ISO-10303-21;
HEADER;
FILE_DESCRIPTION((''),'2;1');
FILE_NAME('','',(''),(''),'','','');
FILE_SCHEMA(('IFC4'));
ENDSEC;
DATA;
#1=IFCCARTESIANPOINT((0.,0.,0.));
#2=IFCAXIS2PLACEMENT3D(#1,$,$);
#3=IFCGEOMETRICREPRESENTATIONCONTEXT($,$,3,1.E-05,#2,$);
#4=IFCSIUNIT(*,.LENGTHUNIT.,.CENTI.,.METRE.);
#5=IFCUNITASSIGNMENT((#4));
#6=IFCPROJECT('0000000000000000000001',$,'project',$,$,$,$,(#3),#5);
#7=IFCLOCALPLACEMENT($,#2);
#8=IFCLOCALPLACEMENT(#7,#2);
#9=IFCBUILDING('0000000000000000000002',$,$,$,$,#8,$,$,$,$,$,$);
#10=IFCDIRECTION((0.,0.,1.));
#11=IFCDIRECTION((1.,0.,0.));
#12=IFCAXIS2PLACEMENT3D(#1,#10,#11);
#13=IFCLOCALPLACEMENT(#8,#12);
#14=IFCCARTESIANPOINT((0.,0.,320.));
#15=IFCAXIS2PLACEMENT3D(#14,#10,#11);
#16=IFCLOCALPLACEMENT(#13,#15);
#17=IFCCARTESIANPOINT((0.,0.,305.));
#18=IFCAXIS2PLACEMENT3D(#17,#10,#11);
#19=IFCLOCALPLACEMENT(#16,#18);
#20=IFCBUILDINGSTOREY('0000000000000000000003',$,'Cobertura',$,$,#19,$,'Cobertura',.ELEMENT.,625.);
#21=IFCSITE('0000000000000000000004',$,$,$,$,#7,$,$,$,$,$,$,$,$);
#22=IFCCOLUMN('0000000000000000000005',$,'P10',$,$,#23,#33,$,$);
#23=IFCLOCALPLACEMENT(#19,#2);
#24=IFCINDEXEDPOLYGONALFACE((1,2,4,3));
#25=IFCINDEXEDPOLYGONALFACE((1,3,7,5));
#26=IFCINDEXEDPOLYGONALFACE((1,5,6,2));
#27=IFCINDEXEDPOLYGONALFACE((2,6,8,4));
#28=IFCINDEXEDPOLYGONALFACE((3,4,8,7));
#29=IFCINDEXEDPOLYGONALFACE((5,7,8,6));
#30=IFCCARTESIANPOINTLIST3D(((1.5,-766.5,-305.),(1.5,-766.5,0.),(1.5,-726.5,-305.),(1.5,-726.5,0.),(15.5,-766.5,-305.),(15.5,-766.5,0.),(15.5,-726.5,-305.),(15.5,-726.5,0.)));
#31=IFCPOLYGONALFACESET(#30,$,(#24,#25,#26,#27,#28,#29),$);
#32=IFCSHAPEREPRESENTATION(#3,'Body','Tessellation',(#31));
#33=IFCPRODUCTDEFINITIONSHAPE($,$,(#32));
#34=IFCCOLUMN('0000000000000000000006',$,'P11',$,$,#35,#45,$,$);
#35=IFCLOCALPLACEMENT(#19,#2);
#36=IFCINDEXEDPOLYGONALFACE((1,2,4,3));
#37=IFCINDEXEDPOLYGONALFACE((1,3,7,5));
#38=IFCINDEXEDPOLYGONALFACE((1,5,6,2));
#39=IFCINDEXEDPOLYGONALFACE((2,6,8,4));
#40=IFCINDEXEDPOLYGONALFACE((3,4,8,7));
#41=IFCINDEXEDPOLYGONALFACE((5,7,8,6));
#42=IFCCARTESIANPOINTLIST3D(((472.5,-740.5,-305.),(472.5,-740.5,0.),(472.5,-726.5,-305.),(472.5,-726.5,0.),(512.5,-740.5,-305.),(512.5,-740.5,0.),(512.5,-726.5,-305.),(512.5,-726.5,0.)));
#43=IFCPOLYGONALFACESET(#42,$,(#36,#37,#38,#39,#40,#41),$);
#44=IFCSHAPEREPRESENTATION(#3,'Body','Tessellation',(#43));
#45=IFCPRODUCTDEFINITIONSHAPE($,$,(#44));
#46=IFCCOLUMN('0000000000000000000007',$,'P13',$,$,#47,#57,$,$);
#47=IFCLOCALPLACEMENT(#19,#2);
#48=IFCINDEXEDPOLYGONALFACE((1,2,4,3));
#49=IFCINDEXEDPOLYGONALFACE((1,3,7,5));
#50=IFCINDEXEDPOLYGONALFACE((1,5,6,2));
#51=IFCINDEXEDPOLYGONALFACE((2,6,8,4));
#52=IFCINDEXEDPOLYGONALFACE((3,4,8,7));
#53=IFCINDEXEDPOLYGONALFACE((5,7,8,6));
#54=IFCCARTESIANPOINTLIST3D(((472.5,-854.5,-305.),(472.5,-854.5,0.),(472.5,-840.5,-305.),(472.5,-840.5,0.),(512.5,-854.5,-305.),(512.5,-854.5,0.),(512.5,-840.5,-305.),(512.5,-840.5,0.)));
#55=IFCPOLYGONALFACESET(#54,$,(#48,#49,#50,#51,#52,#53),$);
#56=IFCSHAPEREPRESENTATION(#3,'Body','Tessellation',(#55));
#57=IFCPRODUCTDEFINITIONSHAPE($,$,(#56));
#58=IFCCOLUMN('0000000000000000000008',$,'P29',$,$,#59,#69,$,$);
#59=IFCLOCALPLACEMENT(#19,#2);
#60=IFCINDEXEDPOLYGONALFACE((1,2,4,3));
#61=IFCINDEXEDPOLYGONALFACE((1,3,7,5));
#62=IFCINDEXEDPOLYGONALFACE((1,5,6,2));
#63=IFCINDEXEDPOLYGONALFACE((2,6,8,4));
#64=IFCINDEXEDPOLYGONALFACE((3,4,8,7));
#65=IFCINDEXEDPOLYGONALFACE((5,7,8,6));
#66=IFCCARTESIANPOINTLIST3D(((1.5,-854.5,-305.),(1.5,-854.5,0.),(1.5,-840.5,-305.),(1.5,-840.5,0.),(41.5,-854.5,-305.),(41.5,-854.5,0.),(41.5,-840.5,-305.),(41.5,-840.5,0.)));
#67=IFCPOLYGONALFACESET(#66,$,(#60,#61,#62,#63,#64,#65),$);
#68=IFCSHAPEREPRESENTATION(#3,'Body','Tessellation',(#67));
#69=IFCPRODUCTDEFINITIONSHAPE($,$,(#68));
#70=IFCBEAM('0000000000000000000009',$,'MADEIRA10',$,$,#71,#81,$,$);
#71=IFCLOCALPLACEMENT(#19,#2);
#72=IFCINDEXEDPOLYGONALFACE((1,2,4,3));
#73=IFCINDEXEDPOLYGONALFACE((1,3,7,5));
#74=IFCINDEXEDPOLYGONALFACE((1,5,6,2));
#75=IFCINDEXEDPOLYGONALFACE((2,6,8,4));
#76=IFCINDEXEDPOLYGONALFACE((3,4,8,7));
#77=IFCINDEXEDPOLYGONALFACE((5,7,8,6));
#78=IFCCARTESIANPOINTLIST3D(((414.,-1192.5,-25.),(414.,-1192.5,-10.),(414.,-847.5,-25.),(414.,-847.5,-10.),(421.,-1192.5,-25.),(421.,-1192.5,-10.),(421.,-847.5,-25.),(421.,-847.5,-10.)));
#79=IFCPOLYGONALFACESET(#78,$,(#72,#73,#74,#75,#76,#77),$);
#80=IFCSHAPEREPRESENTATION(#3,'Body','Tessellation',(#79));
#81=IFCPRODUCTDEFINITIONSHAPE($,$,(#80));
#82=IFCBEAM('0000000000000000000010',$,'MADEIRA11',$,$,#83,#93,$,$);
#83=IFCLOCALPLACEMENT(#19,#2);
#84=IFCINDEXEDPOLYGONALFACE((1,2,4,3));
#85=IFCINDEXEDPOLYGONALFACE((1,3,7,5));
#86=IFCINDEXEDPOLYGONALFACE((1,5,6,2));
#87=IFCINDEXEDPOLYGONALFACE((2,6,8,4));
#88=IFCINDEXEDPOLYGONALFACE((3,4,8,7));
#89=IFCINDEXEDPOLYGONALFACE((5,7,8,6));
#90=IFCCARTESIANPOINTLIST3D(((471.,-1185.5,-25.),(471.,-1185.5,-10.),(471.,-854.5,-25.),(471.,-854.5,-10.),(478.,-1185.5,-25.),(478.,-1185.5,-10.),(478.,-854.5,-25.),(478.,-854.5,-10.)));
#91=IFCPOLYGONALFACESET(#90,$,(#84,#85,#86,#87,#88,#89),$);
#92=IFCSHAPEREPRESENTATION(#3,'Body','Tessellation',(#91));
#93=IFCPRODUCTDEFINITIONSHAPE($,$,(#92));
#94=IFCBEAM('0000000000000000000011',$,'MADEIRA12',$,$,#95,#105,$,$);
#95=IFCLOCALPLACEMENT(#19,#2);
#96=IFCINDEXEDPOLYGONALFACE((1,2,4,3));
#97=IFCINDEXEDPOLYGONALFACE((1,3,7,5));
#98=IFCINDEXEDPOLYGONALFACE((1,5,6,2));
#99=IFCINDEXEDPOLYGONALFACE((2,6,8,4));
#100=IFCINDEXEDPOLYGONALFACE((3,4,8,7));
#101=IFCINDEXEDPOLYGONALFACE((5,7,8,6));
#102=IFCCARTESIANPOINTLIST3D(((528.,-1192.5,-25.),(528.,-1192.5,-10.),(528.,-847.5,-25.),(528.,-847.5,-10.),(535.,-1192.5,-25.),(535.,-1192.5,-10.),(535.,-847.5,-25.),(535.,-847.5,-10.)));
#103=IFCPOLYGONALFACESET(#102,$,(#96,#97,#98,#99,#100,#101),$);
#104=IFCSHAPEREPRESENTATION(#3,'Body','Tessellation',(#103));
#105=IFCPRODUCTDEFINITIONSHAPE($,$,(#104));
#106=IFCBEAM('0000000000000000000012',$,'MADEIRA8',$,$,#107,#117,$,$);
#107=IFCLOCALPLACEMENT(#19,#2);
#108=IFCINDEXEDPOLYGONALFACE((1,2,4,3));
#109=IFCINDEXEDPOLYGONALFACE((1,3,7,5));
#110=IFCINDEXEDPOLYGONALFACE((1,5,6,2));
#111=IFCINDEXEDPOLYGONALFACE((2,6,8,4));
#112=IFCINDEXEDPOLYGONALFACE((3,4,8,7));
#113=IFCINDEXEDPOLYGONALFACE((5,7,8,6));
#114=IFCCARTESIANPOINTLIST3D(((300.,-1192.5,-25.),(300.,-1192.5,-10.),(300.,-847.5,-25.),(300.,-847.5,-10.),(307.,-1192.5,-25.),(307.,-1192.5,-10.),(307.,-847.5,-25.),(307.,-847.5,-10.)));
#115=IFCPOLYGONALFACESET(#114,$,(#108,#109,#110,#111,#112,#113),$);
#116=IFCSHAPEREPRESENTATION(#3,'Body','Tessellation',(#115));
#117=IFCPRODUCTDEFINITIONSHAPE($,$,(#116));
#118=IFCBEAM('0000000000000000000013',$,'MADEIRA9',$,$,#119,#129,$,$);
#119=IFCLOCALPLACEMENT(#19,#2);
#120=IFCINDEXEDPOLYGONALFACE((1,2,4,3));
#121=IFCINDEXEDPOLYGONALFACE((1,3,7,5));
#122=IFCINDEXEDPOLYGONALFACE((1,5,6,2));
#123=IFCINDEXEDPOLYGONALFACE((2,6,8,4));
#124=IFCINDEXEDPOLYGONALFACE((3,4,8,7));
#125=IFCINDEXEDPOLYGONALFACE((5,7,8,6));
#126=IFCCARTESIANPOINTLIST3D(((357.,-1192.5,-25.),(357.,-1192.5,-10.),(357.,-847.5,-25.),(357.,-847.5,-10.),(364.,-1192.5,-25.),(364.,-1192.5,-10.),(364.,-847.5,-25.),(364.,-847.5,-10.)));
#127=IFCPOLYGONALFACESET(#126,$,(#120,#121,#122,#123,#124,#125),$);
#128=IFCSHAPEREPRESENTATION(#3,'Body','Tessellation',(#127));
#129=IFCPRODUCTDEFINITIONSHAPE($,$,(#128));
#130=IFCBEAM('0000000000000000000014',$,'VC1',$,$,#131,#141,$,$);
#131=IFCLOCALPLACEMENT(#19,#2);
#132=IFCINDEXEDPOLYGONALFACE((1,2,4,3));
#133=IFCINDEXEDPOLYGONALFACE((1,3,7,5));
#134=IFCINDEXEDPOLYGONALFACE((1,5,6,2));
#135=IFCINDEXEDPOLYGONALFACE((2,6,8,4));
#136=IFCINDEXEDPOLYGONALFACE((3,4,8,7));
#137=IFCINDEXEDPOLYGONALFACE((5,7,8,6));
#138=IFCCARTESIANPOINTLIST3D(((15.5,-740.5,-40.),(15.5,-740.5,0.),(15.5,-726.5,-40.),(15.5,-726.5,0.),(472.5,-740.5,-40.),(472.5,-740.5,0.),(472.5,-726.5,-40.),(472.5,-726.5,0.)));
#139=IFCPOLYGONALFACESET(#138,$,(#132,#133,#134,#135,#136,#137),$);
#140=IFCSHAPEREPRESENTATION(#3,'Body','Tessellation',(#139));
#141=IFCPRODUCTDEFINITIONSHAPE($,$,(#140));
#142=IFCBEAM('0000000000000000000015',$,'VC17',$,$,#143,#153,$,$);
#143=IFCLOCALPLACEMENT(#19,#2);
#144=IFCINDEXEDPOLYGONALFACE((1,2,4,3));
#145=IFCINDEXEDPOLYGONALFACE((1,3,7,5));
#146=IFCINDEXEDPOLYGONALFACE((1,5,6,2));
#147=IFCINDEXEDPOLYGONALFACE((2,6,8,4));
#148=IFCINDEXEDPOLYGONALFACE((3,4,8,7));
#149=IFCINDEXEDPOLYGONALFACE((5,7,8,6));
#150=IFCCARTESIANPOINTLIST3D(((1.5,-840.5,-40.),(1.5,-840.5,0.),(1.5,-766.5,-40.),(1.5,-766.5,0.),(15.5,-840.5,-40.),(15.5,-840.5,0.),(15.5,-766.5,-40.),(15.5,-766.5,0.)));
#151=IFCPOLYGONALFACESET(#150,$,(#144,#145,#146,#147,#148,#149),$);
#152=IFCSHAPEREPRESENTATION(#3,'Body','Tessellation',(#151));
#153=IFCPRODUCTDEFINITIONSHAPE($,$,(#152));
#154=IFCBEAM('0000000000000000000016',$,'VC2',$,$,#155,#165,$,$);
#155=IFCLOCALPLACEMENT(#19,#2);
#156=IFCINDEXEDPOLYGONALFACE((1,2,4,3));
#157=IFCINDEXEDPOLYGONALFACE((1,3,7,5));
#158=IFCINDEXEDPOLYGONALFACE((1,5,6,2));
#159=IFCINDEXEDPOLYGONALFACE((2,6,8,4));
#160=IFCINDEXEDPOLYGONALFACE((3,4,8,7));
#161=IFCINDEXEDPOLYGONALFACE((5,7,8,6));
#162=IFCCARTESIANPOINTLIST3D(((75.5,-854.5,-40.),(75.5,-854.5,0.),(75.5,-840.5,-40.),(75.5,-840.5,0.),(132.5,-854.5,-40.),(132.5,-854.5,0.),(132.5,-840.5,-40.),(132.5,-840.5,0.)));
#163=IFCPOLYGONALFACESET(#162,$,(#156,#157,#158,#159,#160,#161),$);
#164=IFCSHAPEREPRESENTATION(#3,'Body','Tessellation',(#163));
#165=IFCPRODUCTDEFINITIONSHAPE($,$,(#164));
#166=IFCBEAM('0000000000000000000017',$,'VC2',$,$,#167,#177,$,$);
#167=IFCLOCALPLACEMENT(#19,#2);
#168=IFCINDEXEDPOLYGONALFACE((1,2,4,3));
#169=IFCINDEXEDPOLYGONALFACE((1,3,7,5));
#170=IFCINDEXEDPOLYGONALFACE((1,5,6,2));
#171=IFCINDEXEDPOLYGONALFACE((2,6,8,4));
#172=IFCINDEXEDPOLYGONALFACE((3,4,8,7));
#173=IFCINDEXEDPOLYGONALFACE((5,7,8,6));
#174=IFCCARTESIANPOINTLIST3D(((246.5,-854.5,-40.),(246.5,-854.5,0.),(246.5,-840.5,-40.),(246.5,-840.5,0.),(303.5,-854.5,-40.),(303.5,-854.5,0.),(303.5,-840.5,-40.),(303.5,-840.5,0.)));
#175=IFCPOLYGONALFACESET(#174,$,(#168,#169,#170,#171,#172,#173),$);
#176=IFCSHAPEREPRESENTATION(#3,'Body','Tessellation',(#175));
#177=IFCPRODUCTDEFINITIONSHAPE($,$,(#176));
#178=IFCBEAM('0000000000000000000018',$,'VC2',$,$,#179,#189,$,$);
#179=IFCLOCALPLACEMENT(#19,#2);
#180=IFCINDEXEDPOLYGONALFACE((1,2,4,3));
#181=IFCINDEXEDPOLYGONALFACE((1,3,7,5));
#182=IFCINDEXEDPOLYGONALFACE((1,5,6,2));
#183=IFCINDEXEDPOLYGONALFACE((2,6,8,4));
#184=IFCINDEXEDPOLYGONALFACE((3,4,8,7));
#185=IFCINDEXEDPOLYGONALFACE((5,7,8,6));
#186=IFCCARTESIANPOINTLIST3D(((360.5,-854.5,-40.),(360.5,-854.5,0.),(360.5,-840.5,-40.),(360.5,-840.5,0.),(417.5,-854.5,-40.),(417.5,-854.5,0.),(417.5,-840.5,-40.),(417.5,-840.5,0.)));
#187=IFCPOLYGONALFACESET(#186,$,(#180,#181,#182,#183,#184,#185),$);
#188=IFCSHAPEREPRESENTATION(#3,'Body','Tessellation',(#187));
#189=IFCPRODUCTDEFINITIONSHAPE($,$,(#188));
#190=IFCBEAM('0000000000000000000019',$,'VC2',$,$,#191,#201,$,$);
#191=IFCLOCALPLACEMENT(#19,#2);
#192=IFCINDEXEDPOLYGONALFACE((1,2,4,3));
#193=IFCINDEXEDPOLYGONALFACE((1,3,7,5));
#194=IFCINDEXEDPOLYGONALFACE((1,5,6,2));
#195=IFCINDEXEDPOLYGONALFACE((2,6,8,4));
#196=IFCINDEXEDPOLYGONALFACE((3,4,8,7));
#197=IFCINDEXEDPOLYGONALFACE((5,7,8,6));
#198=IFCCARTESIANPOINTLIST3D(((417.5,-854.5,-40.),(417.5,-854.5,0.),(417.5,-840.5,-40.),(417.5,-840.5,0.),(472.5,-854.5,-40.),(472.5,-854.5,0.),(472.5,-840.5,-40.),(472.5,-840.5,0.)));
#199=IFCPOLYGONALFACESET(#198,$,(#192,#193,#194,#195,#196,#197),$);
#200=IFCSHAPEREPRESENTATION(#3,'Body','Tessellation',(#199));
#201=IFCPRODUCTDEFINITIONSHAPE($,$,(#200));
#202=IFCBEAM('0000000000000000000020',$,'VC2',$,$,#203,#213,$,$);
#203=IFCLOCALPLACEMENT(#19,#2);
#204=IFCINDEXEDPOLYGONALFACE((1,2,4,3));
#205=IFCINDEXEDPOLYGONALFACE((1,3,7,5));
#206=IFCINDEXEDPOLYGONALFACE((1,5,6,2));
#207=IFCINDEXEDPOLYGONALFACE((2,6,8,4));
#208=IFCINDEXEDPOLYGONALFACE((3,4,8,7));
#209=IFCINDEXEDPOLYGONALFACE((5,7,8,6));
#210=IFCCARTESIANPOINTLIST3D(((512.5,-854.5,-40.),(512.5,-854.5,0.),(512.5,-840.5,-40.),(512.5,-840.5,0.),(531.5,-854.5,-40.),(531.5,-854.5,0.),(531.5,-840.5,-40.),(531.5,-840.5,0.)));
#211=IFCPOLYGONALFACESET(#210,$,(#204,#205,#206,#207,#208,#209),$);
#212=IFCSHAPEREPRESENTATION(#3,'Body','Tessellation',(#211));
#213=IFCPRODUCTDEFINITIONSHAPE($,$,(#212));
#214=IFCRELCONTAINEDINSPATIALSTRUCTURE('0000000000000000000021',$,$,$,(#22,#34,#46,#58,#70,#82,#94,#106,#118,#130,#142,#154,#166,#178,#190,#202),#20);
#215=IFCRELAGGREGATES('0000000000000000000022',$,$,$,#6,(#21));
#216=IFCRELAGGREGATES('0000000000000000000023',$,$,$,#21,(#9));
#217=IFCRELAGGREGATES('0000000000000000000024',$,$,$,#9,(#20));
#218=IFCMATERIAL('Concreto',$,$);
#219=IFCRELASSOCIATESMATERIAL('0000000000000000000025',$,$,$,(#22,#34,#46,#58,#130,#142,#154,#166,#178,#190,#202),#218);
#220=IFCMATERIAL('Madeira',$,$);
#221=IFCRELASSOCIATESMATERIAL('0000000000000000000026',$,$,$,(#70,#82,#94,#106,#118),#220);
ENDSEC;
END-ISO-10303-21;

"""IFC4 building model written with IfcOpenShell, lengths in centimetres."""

from ifc_helpers import new_model, si_unit, frame, origin, origin_with_axes, place, context, project, spatial, polyline, outline, extrude, material, element, save


model = new_model("IFC4")

# Units and contexts
context_of_model = context(None, 3, precision=1e-05, world=origin())
ifc_project = project(units=[si_unit("LENGTHUNIT", "METRE", prefix="CENTI")], contexts=[context_of_model])

# Site, building, storey
site_placement = place(None, origin())
site = spatial("IfcSite", under=ifc_project, at=site_placement)
building_placement = place(site_placement, origin())
building = spatial("IfcBuilding", under=site, at=building_placement)
placement_1 = place(building_placement, origin_with_axes())
placement_2 = place(placement_1, frame((0.0, 0.0, 320.0), z_axis=(0.0, 0.0, 1.0), x_axis=(1.0, 0.0, 0.0)))
storey_placement = place(placement_2, frame((0.0, 0.0, 305.0), z_axis=(0.0, 0.0, 1.0), x_axis=(1.0, 0.0, 0.0)))
storey = spatial("IfcBuildingStorey", under=building, at=storey_placement, Name="Cobertura", LongName="Cobertura", CompositionType="ELEMENT", Elevation=625.0)

# Columns
ifc_material_1 = material(Name="Concreto")
column_1_placement = place(storey_placement, frame((8.5, -746.5, 0.0), z_axis=(0.0, 0.0, 1.0), x_axis=(1.0, 0.0, 0.0)))
element("IfcColumn", 1, at=column_1_placement, inside=storey, material=ifc_material_1, Name="P10", context=context_of_model, shape_type="SolidModel", body=[
    extrude(outline(polyline([(7.0, 20.0), (-7.0, 20.0), (-7.0, -20.0), (7.0, -20.0), (7.0, 20.0)])), frame((0.0, 0.0, 0.0), z_axis=(0.0, 0.0, 1.0), x_axis=(1.0, 0.0, 0.0)), (0.0, 0.0, -1.0), 305.0),
])
for number, where, z_axis, x_axis, name in (
    (2, (492.5, -733.5, 0.0), (0.0, 0.0, 1.0), (1.0, 0.0, 0.0), "P11"),
    (3, (492.5, -847.5, 0.0), (0.0, 0.0, 1.0), (1.0, 0.0, 0.0), "P13"),
):
    element("IfcColumn", number, at=place(storey_placement, frame(where, z_axis=z_axis, x_axis=x_axis)), inside=storey, material=ifc_material_1, Name=name, context=context_of_model, shape_type="SolidModel", body=[
        extrude(outline(polyline([(-20.0, 7.0), (-20.0, -7.0), (20.0, -7.0), (20.0, 7.0), (-20.0, 7.0)])), origin_with_axes(), (0.0, 0.0, -1.0), 305.0),
    ])
column_2_placement = place(storey_placement, frame((21.5, -847.5, 0.0), z_axis=(0.0, 0.0, 1.0), x_axis=(1.0, 0.0, 0.0)))
element("IfcColumn", 4, at=column_2_placement, inside=storey, material=ifc_material_1, Name="P29", context=context_of_model, shape_type="SolidModel", body=[
    extrude(outline(polyline([(20.0, -7.0), (20.0, 7.0), (-20.0, 7.0), (-20.0, -7.0), (20.0, -7.0)])), origin_with_axes(), (0.0, 0.0, -1.0), 305.0),
])

# Beams
ifc_material_2 = material(Name="Madeira")
beam_1_placement = place(storey_placement, frame((417.5, -1020.0, -10.0), z_axis=(0.0, 0.0, 1.0), x_axis=(1.0, 0.0, 0.0)))
element("IfcBeam", 5, at=beam_1_placement, inside=storey, material=ifc_material_2, Name="MADEIRA10", context=context_of_model, shape_type="SolidModel", body=[
    extrude(outline(polyline([(-3.5, -7.5), (-3.5, 7.5), (3.5, 7.5), (3.5, -7.5), (-3.5, -7.5)])), frame((0.0, -172.5, -7.5), z_axis=(0.0, 1.0, 0.0), x_axis=(1.0, 0.0, 0.0)), (0.0, 0.0, 1.0), 345.0),
])
beam_2_placement = place(storey_placement, frame((474.5, -1020.0, -10.0), z_axis=(0.0, 0.0, 1.0), x_axis=(1.0, 0.0, 0.0)))
element("IfcBeam", 6, at=beam_2_placement, inside=storey, material=ifc_material_2, Name="MADEIRA11", context=context_of_model, shape_type="SolidModel", body=[
    extrude(outline(polyline([(-3.5, -7.5), (-3.5, 7.5), (3.5, 7.5), (3.5, -7.5), (-3.5, -7.5)])), frame((0.0, -165.5, -7.5), z_axis=(0.0, 1.0, 0.0), x_axis=(1.0, 0.0, 0.0)), (0.0, 0.0, 1.0), 331.0),
])
for number, where, z_axis, x_axis, name in (
    (7, (531.5, -1020.0, -10.0), (0.0, 0.0, 1.0), (1.0, 0.0, 0.0), "MADEIRA12"),
    (8, (303.5, -1020.0, -10.0), (0.0, 0.0, 1.0), (1.0, 0.0, 0.0), "MADEIRA8"),
    (9, (360.5, -1020.0, -10.0), (0.0, 0.0, 1.0), (1.0, 0.0, 0.0), "MADEIRA9"),
):
    element("IfcBeam", number, at=place(storey_placement, frame(where, z_axis=z_axis, x_axis=x_axis)), inside=storey, material=ifc_material_2, Name=name, context=context_of_model, shape_type="SolidModel", body=[
        extrude(outline(polyline([(-3.5, -7.5), (-3.5, 7.5), (3.5, 7.5), (3.5, -7.5), (-3.5, -7.5)])), frame((0.0, -172.5, -7.5), z_axis=(0.0, 1.0, 0.0), x_axis=(1.0, 0.0, 0.0)), (0.0, 0.0, 1.0), 345.0),
    ])
beam_3_placement = place(storey_placement, frame((244.0, -733.5, 0.0), z_axis=(0.0, 0.0, 1.0), x_axis=(1.0, 0.0, 0.0)))
element("IfcBeam", 10, at=beam_3_placement, inside=storey, material=ifc_material_1, Name="VC1", context=context_of_model, shape_type="SolidModel", body=[
    extrude(outline(polyline([(-7.0, -20.0), (7.0, -20.0), (7.0, 20.0), (-7.0, 20.0), (-7.0, -20.0)])), frame((-228.5, 0.0, -20.0), z_axis=(1.0, 0.0, 0.0), x_axis=(0.0, -1.0, 0.0)), (0.0, 0.0, 1.0), 457.0),
])
beam_4_placement = place(storey_placement, frame((8.5, -803.5, 0.0), z_axis=(0.0, 0.0, 1.0), x_axis=(1.0, 0.0, 0.0)))
element("IfcBeam", 11, at=beam_4_placement, inside=storey, material=ifc_material_1, Name="VC17", context=context_of_model, shape_type="SolidModel", body=[
    extrude(outline(polyline([(-7.0, -20.0), (7.0, -20.0), (7.0, 20.0), (-7.0, 20.0), (-7.0, -20.0)])), frame((0.0, -37.0, -20.0), z_axis=(0.0, 1.0, 0.0), x_axis=(1.0, 0.0, 0.0)), (0.0, 0.0, 1.0), 74.0),
])
for number, where, z_axis, x_axis, name in (
    (12, (104.0, -847.5, 0.0), (0.0, 0.0, 1.0), (1.0, 0.0, 0.0), "VC2"),
    (13, (275.0, -847.5, 0.0), (0.0, 0.0, 1.0), (1.0, 0.0, 0.0), "VC2"),
    (14, (389.0, -847.5, 0.0), (0.0, 0.0, 1.0), (1.0, 0.0, 0.0), "VC2"),
):
    element("IfcBeam", number, at=place(storey_placement, frame(where, z_axis=z_axis, x_axis=x_axis)), inside=storey, material=ifc_material_1, Name=name, context=context_of_model, shape_type="SolidModel", body=[
        extrude(outline(polyline([(-7.0, -20.0), (7.0, -20.0), (7.0, 20.0), (-7.0, 20.0), (-7.0, -20.0)])), frame((-28.5, 0.0, -20.0), z_axis=(1.0, 0.0, 0.0), x_axis=(0.0, -1.0, 0.0)), (0.0, 0.0, 1.0), 57.0),
    ])
beam_5_placement = place(storey_placement, frame((445.0, -847.5, 0.0), z_axis=(0.0, 0.0, 1.0), x_axis=(1.0, 0.0, 0.0)))
element("IfcBeam", 15, at=beam_5_placement, inside=storey, material=ifc_material_1, Name="VC2", context=context_of_model, shape_type="SolidModel", body=[
    extrude(outline(polyline([(-7.0, -20.0), (7.0, -20.0), (7.0, 20.0), (-7.0, 20.0), (-7.0, -20.0)])), frame((-27.5, 0.0, -20.0), z_axis=(1.0, 0.0, 0.0), x_axis=(0.0, -1.0, 0.0)), (0.0, 0.0, 1.0), 55.0),
])
beam_6_placement = place(storey_placement, frame((522.0, -847.5, 0.0), z_axis=(0.0, 0.0, 1.0), x_axis=(1.0, 0.0, 0.0)))
element("IfcBeam", 16, at=beam_6_placement, inside=storey, material=ifc_material_1, Name="VC2", context=context_of_model, shape_type="SolidModel", body=[
    extrude(outline(polyline([(-7.0, -20.0), (7.0, -20.0), (7.0, 20.0), (-7.0, 20.0), (-7.0, -20.0)])), frame((-9.5, 0.0, -20.0), z_axis=(1.0, 0.0, 0.0), x_axis=(0.0, -1.0, 0.0)), (0.0, 0.0, 1.0), 19.0),
])

save(model, "model.ifc")
